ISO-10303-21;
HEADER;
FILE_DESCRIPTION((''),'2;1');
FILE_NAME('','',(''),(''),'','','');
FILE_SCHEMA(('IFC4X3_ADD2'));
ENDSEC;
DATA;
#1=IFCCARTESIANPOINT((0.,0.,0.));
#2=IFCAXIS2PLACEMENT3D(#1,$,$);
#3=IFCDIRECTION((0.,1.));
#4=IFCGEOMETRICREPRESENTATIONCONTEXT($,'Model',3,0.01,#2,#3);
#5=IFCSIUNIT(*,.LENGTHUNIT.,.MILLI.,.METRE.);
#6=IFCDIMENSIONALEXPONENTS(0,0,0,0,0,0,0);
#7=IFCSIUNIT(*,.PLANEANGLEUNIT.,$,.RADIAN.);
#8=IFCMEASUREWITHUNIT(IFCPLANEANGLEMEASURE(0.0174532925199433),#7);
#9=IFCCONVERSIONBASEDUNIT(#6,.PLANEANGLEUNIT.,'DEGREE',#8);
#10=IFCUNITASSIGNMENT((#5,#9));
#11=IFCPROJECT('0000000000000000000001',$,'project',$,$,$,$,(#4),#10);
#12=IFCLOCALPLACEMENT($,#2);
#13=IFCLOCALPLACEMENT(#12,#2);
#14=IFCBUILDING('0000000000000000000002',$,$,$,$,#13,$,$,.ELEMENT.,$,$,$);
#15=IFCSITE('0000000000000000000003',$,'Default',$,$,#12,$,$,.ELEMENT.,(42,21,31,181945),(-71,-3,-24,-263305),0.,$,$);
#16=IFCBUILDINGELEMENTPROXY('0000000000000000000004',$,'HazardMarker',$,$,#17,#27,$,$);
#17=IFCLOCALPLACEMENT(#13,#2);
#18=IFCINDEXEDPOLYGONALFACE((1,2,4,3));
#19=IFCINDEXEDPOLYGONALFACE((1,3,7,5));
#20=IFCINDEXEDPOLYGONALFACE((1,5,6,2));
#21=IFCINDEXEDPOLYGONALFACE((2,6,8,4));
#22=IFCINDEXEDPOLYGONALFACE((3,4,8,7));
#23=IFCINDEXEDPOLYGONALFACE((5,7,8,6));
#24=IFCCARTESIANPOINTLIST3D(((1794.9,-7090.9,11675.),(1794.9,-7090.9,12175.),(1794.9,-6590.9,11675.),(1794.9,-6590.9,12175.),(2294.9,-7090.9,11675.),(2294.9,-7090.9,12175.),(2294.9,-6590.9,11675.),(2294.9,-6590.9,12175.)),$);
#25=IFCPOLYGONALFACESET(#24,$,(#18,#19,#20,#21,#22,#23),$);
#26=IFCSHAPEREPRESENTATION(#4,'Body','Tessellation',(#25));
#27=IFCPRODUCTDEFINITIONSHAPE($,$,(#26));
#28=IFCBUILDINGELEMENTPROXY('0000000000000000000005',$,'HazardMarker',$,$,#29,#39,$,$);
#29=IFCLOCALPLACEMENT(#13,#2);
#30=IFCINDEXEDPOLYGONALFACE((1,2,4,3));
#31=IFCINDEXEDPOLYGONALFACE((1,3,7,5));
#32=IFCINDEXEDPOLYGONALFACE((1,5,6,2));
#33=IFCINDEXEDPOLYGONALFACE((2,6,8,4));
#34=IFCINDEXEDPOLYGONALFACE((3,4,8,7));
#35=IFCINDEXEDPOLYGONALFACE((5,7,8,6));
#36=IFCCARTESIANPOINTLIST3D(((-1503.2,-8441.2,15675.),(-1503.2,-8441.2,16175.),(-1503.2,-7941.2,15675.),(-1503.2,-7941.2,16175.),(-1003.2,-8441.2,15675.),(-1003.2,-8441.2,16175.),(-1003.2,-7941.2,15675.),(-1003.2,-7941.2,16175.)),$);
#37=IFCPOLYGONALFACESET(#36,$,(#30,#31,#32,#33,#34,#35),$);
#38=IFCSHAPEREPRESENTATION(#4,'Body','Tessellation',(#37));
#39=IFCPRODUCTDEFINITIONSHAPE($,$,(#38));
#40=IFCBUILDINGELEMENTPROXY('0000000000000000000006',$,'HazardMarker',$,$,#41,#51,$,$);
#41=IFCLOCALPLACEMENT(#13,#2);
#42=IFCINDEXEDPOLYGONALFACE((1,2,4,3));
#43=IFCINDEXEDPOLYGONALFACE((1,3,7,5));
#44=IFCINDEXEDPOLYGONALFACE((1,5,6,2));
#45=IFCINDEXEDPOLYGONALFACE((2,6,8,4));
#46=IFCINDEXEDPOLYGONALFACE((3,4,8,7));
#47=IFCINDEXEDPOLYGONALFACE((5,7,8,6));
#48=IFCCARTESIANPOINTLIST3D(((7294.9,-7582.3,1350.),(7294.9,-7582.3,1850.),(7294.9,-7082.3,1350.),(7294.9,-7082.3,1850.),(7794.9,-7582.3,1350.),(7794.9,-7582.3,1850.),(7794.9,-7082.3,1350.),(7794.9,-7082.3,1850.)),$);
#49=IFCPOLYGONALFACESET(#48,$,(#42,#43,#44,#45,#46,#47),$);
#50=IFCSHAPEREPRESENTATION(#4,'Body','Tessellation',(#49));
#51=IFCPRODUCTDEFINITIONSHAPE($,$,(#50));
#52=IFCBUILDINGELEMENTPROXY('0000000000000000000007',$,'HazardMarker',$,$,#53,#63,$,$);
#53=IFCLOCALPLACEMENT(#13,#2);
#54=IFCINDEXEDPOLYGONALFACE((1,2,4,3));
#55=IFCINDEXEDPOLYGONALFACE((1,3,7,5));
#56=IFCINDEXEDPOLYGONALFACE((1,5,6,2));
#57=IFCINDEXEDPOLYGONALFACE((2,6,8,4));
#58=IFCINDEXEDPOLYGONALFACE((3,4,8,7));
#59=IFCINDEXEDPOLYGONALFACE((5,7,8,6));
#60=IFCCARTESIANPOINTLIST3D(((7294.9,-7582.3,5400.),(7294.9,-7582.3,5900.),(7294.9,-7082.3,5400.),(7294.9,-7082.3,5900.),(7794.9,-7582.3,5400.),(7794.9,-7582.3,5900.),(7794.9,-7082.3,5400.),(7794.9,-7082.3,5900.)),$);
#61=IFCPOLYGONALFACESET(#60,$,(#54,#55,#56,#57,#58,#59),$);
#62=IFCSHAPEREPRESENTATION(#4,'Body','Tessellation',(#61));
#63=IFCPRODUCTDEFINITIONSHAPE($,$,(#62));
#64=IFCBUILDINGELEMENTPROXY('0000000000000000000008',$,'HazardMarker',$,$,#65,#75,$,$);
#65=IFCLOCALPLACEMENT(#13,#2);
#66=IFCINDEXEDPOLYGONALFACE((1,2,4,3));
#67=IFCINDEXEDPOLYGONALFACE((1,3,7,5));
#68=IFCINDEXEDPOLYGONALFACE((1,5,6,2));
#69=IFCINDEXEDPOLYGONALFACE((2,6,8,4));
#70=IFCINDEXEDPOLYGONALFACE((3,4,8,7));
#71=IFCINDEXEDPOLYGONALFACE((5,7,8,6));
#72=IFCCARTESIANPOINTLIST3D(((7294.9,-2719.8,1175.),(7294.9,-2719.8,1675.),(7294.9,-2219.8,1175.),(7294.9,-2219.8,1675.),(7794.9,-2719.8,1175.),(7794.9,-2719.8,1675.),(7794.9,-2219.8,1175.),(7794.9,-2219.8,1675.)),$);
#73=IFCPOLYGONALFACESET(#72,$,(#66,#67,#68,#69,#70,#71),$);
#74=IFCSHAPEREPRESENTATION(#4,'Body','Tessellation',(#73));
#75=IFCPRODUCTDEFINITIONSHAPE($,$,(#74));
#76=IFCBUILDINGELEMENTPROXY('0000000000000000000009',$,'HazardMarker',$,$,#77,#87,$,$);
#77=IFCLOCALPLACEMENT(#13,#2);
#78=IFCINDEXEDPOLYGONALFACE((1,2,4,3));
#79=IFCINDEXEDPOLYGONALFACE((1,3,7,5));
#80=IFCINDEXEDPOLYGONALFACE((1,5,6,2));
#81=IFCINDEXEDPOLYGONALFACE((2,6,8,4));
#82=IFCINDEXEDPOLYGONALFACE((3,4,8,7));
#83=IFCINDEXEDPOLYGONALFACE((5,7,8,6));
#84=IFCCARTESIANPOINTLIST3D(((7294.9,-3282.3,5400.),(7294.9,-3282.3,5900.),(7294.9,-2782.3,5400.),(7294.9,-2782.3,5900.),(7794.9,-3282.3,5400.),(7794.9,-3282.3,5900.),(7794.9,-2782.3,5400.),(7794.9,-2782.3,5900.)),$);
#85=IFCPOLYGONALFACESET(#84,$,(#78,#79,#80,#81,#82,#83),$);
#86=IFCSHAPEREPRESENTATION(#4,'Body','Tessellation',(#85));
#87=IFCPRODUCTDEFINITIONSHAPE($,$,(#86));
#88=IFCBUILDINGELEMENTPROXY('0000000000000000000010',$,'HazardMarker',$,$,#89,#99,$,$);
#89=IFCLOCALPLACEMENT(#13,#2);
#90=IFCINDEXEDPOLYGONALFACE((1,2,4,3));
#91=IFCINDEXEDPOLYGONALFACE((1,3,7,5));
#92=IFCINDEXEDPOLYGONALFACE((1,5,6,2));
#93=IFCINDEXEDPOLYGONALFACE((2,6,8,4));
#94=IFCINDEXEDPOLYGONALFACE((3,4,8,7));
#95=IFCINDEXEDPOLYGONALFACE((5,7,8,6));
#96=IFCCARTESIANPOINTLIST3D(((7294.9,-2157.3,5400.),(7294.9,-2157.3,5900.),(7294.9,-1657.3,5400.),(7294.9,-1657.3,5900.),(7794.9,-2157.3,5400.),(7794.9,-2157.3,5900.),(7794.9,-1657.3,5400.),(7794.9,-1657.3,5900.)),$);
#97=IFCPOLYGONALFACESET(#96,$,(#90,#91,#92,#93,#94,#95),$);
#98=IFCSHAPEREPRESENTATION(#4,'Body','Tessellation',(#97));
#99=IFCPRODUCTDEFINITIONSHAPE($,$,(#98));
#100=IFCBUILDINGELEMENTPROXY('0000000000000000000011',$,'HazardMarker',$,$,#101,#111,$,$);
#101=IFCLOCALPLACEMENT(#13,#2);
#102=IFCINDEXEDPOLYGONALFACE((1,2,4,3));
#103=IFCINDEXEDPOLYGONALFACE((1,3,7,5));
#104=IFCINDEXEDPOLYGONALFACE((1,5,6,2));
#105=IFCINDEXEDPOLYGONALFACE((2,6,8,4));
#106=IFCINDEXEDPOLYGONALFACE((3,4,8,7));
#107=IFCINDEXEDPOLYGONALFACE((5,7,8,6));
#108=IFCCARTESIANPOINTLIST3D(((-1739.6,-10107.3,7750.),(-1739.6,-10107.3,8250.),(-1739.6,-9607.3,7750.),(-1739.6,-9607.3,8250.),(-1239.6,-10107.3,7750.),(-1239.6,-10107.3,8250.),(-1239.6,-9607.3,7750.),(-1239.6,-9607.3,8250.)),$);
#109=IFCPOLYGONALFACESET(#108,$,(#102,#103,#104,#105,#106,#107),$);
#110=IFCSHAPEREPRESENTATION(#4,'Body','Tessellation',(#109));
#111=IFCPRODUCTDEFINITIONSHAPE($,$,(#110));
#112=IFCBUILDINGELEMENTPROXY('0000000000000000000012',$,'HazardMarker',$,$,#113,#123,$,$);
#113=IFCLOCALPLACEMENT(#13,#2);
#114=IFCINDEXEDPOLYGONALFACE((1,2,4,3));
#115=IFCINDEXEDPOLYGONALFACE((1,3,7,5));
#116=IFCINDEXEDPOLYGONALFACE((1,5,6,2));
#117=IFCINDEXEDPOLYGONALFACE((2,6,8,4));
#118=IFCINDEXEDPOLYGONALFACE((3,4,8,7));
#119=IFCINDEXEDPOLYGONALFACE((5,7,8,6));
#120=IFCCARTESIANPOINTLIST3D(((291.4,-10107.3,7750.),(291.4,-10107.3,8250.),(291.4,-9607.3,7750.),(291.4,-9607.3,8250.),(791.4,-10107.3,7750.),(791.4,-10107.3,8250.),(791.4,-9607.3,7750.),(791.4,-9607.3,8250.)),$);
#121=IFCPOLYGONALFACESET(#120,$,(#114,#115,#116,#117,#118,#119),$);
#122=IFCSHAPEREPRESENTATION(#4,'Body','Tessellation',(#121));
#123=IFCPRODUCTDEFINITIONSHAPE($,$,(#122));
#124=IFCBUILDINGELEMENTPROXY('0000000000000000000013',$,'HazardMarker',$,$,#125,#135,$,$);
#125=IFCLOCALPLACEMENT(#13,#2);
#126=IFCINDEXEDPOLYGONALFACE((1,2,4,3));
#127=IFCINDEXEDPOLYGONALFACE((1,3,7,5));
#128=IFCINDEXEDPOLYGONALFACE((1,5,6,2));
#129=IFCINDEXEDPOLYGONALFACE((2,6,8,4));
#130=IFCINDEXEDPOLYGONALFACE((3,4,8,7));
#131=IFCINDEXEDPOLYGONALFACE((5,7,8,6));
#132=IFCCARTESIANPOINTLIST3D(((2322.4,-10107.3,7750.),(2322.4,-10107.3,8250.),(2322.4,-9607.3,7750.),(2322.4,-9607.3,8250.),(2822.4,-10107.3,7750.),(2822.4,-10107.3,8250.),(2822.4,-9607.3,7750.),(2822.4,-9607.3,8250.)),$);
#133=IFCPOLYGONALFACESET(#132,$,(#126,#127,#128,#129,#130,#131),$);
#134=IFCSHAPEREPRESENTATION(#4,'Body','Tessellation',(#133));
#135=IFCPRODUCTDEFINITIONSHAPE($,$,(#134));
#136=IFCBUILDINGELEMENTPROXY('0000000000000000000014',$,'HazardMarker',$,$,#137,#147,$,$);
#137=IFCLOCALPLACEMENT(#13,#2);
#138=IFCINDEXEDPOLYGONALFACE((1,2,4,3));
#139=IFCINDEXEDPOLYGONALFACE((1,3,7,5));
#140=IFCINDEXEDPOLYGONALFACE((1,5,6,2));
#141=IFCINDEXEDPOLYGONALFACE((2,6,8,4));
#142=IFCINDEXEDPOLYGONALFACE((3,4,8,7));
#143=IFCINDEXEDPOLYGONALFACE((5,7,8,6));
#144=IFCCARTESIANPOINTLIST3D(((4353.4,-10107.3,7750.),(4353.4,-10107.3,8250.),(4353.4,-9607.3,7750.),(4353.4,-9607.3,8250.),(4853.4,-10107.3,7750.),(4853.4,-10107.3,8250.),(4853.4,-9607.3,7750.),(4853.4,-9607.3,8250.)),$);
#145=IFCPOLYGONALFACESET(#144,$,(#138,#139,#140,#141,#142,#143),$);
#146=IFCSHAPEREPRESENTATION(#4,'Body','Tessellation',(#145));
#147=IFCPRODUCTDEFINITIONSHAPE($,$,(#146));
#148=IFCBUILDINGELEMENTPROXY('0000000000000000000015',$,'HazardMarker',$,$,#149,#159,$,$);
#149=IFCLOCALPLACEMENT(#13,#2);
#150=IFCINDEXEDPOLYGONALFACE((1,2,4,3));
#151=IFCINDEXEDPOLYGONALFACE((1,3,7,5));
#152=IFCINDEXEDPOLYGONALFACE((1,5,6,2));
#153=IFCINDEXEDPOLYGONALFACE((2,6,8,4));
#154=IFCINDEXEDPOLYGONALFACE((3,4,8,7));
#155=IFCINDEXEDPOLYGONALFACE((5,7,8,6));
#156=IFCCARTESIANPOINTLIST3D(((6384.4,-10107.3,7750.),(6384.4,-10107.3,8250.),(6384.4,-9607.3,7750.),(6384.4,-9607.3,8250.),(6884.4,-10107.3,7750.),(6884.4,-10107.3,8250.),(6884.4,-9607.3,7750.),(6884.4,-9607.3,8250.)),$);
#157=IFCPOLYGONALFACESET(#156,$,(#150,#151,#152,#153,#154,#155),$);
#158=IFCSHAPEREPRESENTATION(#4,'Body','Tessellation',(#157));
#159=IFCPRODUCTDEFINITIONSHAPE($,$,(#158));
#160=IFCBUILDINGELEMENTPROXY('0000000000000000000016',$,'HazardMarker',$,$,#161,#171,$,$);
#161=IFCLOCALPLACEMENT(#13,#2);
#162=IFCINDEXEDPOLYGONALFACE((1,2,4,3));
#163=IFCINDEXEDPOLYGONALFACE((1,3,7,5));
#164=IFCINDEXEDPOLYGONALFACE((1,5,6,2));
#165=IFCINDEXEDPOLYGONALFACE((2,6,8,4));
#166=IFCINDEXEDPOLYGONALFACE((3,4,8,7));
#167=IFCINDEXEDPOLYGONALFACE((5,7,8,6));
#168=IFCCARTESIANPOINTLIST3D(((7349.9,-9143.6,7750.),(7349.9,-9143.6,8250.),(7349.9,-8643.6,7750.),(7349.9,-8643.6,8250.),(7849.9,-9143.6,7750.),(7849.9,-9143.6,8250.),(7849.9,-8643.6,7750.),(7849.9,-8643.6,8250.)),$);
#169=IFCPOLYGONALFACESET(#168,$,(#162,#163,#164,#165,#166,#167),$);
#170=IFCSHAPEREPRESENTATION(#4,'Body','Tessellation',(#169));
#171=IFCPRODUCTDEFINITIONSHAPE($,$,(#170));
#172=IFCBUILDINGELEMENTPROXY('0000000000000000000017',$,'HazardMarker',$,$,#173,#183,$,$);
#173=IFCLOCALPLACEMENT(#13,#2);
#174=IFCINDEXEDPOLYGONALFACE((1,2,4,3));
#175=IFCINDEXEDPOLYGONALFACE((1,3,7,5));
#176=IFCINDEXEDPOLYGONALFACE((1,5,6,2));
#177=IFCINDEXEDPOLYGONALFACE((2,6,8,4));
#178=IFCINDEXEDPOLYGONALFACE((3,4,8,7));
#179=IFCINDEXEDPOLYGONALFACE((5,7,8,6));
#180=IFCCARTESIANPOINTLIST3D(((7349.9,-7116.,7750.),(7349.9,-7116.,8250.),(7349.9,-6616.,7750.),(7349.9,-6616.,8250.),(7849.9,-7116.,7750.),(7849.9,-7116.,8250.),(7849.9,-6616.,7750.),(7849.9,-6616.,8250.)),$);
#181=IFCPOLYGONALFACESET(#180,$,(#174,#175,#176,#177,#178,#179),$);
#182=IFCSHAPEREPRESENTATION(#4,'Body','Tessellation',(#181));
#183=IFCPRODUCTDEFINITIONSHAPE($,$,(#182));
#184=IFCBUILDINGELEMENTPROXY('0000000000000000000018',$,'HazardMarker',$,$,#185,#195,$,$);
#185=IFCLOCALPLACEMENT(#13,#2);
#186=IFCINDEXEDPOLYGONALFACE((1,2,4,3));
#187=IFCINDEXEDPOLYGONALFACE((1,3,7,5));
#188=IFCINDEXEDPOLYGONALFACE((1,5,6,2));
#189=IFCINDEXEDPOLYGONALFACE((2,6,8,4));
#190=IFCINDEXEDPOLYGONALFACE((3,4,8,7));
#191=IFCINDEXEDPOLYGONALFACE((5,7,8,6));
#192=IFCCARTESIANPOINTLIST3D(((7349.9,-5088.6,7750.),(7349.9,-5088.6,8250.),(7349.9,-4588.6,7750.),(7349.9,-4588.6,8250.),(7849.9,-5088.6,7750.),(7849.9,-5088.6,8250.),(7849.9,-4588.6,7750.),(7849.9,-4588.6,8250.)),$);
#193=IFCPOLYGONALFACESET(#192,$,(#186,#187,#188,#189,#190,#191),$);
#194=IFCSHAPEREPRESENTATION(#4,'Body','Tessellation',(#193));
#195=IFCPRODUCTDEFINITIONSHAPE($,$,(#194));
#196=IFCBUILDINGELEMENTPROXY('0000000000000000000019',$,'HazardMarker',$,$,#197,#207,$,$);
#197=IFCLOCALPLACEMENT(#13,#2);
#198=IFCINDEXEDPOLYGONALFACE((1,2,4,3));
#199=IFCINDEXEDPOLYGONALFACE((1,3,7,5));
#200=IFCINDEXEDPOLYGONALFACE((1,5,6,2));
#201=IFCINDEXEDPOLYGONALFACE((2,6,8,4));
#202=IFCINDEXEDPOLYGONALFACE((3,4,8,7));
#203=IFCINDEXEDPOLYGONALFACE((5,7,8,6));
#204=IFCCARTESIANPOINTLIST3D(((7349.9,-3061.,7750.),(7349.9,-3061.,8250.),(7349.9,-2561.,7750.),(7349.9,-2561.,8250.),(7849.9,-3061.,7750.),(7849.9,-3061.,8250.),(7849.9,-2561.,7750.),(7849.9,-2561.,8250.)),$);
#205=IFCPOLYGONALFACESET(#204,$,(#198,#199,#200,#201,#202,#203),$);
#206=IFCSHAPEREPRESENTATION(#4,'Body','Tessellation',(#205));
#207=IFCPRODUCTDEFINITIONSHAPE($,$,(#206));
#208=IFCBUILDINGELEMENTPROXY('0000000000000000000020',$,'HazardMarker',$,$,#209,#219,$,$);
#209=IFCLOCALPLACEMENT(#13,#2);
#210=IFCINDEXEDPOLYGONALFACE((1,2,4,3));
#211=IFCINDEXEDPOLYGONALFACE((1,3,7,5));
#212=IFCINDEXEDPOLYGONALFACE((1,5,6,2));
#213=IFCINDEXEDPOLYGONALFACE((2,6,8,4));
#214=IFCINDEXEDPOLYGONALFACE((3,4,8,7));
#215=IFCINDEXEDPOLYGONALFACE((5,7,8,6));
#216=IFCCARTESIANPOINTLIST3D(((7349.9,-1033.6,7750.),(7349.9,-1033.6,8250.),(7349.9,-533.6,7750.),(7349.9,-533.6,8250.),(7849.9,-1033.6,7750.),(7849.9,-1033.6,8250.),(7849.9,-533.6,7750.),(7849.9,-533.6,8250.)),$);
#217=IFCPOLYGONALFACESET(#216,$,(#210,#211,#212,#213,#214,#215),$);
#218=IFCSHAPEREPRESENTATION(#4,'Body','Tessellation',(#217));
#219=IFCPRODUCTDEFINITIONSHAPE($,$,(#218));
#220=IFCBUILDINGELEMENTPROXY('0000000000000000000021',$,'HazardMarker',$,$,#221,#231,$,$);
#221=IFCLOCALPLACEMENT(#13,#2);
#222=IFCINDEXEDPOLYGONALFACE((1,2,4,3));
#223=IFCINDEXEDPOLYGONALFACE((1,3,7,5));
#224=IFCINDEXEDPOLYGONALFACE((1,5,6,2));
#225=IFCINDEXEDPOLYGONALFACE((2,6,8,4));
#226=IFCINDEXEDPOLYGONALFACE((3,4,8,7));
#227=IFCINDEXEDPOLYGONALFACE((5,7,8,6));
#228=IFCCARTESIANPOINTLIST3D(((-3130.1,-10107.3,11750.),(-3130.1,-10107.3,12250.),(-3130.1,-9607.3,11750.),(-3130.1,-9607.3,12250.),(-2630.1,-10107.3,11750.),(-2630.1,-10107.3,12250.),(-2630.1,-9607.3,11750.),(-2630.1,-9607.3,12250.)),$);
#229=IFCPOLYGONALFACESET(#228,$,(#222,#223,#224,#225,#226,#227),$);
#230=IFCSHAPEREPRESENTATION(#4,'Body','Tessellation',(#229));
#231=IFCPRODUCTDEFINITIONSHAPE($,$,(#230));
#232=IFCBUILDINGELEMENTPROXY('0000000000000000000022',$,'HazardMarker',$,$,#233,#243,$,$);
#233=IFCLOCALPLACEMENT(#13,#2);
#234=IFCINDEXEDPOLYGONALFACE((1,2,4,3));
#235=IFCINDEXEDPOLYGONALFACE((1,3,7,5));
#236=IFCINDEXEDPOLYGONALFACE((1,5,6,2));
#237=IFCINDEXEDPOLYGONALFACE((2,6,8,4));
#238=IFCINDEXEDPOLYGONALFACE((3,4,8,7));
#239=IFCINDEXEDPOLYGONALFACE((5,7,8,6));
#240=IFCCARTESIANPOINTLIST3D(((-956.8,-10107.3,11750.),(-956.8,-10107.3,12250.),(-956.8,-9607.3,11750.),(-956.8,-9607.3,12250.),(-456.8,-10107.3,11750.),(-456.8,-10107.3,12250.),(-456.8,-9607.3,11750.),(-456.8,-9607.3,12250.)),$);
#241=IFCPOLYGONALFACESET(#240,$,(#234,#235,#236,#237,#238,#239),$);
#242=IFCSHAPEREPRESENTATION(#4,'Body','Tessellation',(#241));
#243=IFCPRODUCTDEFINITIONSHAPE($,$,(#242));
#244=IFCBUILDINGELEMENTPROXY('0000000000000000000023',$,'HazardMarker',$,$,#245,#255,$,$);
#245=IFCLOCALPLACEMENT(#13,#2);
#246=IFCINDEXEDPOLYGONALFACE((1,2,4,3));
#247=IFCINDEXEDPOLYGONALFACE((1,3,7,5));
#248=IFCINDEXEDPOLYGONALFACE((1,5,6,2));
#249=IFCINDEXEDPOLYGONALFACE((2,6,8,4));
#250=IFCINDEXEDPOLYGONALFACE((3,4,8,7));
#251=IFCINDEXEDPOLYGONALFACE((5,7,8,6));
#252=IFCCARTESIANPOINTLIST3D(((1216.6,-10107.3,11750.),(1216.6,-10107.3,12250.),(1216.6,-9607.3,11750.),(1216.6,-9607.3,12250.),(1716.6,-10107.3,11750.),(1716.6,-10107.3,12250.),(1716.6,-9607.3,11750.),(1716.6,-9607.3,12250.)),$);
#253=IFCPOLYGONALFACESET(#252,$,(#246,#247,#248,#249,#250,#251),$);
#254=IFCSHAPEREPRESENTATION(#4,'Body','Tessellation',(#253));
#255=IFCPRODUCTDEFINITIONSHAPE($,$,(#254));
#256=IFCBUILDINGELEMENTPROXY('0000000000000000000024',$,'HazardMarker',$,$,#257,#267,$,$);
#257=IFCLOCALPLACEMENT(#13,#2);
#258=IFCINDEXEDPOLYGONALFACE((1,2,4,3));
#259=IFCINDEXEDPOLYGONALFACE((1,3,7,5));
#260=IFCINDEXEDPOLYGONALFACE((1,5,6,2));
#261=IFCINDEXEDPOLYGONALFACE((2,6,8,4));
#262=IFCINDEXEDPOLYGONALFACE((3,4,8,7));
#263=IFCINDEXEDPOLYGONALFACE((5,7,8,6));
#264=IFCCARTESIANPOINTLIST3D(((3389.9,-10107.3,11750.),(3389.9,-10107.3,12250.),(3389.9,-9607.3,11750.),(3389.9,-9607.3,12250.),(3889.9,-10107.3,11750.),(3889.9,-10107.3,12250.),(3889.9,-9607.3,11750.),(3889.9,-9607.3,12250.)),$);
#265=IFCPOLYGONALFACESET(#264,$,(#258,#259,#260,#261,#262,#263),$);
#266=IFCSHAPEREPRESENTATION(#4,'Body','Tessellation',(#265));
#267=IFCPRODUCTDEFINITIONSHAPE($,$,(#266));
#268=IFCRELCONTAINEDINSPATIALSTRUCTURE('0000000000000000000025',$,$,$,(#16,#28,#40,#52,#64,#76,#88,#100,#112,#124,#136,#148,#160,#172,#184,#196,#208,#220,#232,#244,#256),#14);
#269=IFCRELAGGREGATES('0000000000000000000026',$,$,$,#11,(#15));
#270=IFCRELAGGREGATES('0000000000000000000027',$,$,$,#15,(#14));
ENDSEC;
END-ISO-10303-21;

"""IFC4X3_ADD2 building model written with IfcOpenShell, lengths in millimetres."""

from ifc_helpers import new_model, entity, si_unit, converted_unit, direction, frame, origin, place, context, project, spatial, rectangle, extrude, element, save


model = new_model("IFC4X3_ADD2")

# Units and contexts
model_context = context("Model", 3, precision=0.01, world=origin(), true_north=direction((0.0, 1.0)))
ifc_project = project(units=[si_unit("LENGTHUNIT", "METRE", prefix="MILLI"), converted_unit("PLANEANGLEUNIT", "DEGREE", entity("IfcPlaneAngleMeasure", 0.0174532925199433), si_unit("PLANEANGLEUNIT", "RADIAN"), dimensions=[0, 0, 0, 0, 0, 0, 0])], contexts=[model_context])

# Site, building
site_placement = place(None, origin())
site = spatial("IfcSite", under=ifc_project, at=site_placement, Name="Default", CompositionType="ELEMENT", RefLatitude=(42, 21, 31, 181945), RefLongitude=(-71, -3, -24, -263305), RefElevation=0.0)
building_placement = place(site_placement, origin())
building = spatial("IfcBuilding", under=site, at=building_placement, CompositionType="ELEMENT")

# Building element proxies
for number, where, name in (
    (1, (2044.9, -6840.9, 11925.0), "HazardMarker"),
    (2, (-1253.2, -8191.2, 15925.0), "HazardMarker"),
    (3, (7544.9, -7332.3, 1600.0), "HazardMarker"),
    (4, (7544.9, -7332.3, 5650.0), "HazardMarker"),
    (5, (7544.9, -2469.8, 1425.0), "HazardMarker"),
    (6, (7544.9, -3032.3, 5650.0), "HazardMarker"),
    (7, (7544.9, -1907.3, 5650.0), "HazardMarker"),
    (8, (-1489.6, -9857.3, 8000.0), "HazardMarker"),
    (9, (541.4, -9857.3, 8000.0), "HazardMarker"),
    (10, (2572.4, -9857.3, 8000.0), "HazardMarker"),
    (11, (4603.4, -9857.3, 8000.0), "HazardMarker"),
    (12, (6634.4, -9857.3, 8000.0), "HazardMarker"),
    (13, (7599.9, -8893.5, 8000.0), "HazardMarker"),
    (14, (7599.9, -6866.1, 8000.0), "HazardMarker"),
    (15, (7599.9, -4838.6, 8000.0), "HazardMarker"),
    (16, (7599.9, -2811.1, 8000.0), "HazardMarker"),
    (17, (7599.9, -783.5, 8000.0), "HazardMarker"),
    (18, (-2880.1, -9857.3, 12000.0), "HazardMarker"),
    (19, (-706.8, -9857.3, 12000.0), "HazardMarker"),
    (20, (1466.6, -9857.3, 12000.0), "HazardMarker"),
    (21, (3639.9, -9857.3, 12000.0), "HazardMarker"),
):
    element("IfcBuildingElementProxy", number, at=place(None, frame(where)), inside=building, Name=name, context=model_context, shape_type="SweptSolid", body=[
        extrude(rectangle(XDim=500.0, YDim=500.0), frame((0.0, 0.0, -250.0)), (0.0, 0.0, 1.0), 500.0),
    ])

save(model, "model.ifc")
